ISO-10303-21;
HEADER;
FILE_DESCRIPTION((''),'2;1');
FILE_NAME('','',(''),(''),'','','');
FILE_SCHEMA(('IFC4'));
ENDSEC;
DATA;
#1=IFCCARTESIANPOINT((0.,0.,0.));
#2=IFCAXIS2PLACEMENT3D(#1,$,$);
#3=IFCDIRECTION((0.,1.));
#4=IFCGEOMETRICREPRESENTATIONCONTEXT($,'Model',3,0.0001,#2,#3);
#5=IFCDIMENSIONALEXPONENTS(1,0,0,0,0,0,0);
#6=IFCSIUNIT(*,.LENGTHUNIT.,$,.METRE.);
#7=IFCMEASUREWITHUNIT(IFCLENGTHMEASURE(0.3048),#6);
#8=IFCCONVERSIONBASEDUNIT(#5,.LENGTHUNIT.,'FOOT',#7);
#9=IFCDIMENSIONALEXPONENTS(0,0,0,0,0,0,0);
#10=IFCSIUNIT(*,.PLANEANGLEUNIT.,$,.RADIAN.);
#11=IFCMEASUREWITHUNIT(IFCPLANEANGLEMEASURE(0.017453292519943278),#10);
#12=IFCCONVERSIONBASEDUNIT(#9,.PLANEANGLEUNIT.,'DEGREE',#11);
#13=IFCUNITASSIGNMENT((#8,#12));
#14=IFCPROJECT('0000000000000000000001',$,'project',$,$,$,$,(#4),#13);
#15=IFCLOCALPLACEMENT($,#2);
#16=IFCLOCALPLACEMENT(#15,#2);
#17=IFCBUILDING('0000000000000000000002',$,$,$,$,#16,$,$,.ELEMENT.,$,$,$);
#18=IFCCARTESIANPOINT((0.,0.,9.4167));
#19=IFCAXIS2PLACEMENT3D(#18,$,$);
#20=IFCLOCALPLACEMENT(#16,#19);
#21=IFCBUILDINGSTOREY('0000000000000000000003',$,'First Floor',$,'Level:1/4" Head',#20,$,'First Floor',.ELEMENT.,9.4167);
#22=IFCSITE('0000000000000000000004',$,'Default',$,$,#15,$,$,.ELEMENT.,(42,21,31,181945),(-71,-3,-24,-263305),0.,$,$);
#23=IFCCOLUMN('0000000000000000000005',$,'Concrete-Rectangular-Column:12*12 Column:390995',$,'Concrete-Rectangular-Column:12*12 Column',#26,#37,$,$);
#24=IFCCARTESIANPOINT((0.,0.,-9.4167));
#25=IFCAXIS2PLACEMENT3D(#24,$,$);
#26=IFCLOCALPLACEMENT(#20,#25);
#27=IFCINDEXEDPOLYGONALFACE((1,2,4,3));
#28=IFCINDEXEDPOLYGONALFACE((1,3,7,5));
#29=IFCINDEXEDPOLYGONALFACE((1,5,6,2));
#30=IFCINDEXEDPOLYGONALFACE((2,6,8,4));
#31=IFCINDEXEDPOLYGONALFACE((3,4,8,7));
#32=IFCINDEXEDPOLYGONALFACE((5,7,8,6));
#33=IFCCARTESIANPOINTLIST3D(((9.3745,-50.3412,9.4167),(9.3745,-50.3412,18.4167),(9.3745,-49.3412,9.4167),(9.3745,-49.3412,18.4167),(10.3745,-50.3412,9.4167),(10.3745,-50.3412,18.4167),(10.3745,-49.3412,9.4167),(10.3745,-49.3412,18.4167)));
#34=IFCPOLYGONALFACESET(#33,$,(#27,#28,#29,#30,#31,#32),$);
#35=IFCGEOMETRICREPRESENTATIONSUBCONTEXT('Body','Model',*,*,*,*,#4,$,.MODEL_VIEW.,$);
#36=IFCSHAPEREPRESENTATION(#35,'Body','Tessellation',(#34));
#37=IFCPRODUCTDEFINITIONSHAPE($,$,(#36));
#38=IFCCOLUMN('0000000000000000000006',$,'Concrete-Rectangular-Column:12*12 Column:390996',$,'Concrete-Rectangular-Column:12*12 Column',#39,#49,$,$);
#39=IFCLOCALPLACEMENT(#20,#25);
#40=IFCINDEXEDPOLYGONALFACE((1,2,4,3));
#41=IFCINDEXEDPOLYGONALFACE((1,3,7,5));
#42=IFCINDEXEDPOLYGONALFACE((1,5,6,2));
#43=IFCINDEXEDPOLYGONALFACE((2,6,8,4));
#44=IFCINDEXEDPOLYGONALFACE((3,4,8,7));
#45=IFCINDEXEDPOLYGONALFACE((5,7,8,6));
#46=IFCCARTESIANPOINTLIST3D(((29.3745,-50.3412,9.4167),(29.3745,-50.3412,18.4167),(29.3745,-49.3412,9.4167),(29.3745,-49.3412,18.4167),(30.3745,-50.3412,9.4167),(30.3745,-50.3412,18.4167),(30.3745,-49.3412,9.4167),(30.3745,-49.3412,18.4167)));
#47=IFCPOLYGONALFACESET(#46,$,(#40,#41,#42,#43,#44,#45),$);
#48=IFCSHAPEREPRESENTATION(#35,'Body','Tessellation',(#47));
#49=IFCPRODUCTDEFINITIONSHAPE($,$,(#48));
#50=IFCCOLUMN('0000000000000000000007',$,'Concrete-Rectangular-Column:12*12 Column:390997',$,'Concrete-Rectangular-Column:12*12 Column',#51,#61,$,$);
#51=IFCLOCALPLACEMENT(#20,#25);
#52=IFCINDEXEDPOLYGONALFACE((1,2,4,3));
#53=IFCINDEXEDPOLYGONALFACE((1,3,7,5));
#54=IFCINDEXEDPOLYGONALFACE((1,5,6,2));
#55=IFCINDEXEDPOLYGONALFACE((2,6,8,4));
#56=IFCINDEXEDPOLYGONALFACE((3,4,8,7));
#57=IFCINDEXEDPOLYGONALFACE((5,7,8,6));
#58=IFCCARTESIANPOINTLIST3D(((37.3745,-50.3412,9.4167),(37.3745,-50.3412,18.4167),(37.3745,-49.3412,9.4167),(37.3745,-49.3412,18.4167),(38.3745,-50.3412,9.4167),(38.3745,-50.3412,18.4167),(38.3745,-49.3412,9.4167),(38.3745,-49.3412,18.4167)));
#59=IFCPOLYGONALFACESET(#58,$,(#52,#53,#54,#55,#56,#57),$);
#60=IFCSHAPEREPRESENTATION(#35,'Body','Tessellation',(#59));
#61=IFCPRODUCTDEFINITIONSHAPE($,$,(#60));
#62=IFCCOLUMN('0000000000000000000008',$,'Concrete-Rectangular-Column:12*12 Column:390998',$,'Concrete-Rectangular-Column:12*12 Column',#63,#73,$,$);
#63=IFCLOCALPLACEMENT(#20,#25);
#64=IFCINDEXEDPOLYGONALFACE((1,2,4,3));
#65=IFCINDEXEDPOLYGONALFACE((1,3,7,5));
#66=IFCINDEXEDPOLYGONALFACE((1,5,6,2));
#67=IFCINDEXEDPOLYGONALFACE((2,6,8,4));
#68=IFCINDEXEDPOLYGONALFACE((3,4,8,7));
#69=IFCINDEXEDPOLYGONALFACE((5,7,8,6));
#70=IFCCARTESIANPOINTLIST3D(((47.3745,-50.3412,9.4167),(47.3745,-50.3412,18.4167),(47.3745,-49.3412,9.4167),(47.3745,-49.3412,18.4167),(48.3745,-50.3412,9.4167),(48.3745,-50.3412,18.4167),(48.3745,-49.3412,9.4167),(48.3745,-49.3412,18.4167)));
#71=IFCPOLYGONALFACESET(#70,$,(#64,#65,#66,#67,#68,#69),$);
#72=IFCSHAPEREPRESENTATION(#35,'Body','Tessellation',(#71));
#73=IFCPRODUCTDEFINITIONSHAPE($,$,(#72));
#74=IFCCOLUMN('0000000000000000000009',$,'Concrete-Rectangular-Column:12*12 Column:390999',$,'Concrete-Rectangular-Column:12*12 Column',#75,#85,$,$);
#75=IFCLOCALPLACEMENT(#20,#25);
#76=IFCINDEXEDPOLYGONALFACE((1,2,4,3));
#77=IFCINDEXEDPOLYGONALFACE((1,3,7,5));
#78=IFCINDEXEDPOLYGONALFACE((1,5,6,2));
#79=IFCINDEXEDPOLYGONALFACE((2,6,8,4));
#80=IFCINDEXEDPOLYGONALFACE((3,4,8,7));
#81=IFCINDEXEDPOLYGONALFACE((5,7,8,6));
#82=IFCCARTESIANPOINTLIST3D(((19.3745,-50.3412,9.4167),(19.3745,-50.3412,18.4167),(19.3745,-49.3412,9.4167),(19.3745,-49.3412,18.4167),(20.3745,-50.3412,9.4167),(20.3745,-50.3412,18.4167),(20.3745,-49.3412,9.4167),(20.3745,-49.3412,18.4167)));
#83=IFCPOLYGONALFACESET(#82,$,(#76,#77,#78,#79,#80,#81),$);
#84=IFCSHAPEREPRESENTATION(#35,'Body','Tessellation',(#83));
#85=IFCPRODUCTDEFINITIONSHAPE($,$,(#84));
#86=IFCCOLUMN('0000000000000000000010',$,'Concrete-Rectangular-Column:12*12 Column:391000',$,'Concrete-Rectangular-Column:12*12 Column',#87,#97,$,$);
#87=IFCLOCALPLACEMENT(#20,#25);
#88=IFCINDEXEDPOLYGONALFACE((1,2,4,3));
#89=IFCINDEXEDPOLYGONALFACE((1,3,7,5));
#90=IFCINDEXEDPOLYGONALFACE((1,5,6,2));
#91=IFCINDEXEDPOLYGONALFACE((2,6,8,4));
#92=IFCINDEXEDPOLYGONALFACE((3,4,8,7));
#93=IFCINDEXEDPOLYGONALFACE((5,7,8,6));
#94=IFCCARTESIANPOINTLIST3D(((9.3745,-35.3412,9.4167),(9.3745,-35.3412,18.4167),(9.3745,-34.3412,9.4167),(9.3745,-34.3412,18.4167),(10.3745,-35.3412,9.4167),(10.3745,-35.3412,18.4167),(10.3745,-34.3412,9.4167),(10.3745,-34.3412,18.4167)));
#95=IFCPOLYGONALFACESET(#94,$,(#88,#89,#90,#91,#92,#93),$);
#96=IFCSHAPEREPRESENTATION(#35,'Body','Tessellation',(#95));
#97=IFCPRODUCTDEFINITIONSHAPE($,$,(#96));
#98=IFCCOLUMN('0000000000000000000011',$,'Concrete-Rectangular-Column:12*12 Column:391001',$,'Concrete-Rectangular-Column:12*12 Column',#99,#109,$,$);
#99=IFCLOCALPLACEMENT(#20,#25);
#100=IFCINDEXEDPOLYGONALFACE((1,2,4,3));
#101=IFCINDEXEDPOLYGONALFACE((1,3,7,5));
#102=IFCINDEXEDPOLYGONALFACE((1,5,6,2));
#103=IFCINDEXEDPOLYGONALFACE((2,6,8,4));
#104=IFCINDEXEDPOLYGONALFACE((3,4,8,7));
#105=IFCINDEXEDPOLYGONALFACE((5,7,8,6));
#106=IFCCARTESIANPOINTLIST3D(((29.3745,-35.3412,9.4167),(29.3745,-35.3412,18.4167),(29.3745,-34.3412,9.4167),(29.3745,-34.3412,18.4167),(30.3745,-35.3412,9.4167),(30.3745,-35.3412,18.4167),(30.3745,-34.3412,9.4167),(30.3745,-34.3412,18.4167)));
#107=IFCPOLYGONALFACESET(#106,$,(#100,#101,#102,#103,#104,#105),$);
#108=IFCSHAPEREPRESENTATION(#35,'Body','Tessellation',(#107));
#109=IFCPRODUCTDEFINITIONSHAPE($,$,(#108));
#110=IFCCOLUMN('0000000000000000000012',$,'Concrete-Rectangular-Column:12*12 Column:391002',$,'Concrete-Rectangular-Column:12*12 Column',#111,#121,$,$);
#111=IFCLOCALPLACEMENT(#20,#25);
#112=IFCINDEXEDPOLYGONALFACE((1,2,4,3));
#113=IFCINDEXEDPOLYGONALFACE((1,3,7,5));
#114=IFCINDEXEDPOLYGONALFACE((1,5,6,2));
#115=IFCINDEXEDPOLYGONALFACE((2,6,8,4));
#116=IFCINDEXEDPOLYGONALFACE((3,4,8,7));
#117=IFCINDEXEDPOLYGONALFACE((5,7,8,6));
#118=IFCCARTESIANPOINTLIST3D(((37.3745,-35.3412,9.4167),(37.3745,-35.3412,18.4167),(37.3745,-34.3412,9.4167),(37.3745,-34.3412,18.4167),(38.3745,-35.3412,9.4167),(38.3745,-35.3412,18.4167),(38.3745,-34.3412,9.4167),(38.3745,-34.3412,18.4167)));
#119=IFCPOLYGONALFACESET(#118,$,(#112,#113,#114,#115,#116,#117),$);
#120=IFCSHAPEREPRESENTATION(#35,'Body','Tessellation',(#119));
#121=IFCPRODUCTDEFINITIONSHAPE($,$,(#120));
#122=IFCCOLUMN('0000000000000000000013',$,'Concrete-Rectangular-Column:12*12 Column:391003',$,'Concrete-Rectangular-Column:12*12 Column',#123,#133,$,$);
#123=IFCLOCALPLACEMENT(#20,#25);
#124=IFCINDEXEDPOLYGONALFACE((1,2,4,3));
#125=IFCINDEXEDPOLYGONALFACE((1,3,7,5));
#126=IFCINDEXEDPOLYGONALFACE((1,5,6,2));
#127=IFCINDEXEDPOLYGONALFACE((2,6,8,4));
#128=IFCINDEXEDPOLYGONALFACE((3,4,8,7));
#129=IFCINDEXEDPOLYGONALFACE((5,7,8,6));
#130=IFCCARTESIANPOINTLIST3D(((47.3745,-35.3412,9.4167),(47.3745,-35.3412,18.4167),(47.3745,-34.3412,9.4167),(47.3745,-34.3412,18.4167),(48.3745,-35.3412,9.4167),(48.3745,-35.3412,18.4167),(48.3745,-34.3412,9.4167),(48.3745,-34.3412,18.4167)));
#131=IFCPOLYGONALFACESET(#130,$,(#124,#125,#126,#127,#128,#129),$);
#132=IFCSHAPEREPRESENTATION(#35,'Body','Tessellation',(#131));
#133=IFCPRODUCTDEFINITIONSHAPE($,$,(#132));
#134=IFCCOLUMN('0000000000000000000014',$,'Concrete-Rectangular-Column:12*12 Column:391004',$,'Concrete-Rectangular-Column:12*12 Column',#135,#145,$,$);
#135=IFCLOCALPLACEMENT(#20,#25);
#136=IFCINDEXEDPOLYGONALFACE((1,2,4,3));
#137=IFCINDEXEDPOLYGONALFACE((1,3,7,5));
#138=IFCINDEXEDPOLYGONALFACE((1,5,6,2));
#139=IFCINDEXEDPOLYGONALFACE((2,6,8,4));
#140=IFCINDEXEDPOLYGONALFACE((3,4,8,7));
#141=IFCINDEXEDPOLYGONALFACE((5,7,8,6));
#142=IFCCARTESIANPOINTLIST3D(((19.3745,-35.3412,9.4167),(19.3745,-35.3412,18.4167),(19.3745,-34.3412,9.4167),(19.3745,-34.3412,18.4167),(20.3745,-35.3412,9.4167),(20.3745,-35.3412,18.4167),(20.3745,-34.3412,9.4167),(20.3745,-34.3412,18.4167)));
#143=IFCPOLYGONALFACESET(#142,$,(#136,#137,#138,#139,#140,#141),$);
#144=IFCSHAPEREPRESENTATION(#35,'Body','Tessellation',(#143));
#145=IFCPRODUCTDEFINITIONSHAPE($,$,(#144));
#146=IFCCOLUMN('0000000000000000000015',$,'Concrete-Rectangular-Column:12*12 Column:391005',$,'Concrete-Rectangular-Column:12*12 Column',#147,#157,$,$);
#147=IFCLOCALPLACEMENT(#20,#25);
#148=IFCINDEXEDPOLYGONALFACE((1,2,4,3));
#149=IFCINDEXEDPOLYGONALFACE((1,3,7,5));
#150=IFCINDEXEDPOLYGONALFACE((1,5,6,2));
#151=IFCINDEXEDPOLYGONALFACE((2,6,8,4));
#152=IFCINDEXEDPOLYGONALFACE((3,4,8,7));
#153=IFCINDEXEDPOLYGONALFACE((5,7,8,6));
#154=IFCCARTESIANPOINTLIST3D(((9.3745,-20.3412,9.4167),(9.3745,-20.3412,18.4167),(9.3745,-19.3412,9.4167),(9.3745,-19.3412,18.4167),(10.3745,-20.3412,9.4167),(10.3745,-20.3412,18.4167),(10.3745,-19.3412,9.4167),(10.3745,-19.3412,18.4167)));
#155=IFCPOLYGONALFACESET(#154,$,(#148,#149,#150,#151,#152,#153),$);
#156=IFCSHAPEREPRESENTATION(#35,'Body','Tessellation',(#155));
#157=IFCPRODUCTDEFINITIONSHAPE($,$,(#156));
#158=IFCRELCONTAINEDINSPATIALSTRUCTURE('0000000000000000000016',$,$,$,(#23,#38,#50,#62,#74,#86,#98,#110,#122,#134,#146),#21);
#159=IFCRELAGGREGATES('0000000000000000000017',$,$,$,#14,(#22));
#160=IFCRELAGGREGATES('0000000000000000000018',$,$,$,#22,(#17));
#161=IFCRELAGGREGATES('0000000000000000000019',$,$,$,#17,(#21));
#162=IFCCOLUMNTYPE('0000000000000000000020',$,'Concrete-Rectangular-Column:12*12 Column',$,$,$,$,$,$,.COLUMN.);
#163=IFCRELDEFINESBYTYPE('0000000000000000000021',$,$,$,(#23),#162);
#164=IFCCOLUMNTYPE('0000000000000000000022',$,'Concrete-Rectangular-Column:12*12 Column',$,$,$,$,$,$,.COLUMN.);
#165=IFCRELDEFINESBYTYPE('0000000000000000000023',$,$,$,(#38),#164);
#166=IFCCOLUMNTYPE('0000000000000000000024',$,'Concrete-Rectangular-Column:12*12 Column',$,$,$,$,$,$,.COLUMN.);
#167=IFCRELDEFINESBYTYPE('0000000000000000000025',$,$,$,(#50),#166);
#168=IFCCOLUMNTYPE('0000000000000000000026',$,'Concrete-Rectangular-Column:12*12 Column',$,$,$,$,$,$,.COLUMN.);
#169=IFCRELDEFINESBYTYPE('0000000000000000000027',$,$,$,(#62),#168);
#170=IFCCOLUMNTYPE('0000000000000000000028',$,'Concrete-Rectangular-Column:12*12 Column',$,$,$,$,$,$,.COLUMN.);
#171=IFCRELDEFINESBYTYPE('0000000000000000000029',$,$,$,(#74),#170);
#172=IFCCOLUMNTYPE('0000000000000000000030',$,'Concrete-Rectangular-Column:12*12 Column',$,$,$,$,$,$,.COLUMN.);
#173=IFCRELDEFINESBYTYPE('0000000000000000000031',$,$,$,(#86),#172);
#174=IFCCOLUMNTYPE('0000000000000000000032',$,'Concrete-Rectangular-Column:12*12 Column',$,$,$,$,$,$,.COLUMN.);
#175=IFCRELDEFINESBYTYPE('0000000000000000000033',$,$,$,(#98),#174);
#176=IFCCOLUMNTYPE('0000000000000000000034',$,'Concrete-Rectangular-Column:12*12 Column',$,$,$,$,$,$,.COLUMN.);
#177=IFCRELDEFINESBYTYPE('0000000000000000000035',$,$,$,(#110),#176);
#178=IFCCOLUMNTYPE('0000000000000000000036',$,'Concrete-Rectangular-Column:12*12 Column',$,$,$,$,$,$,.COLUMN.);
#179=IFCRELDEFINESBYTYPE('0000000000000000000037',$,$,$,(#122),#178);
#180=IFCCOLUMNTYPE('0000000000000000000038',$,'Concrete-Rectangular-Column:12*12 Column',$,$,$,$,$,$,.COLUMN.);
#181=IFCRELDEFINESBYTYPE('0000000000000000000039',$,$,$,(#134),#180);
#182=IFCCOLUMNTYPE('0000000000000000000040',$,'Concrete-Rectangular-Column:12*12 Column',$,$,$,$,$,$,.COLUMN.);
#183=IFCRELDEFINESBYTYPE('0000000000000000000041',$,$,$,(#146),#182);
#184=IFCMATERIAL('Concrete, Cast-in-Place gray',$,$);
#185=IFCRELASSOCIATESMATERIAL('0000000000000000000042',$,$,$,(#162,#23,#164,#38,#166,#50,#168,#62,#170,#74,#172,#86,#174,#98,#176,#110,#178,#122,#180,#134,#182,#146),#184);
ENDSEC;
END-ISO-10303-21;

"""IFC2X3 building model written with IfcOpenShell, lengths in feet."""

from ifc_helpers import new_model, entity, si_unit, converted_unit, direction, frame, frame_2d, origin, origin_2d_with_axis, place, context, subcontext, project, spatial, rectangle, extrude, source, transform, mapped, material, type_object, type_shapes, element, save


model = new_model("IFC2X3")

# Units and contexts
model_context = context("Model", 3, precision=0.0001, world=origin(), true_north=direction((0.0, 1.0)))
body_context = subcontext(model_context, "Body", "Model", "MODEL_VIEW")
ifc_project = project(units=[converted_unit("LENGTHUNIT", "FOOT", entity("IfcLengthMeasure", 0.3048), si_unit("LENGTHUNIT", "METRE"), dimensions=[1, 0, 0, 0, 0, 0, 0]), converted_unit("PLANEANGLEUNIT", "DEGREE", entity("IfcPlaneAngleMeasure", 0.017453292519943278), si_unit("PLANEANGLEUNIT", "RADIAN"), dimensions=[0, 0, 0, 0, 0, 0, 0])], contexts=[model_context])

# Site, building, storey
site_placement = place(None, origin())
site = spatial("IfcSite", under=ifc_project, at=site_placement, Name="Default", CompositionType="ELEMENT", RefLatitude=(42, 21, 31, 181945), RefLongitude=(-71, -3, -24, -263305), RefElevation=0.0)
building_placement = place(site_placement, origin())
building = spatial("IfcBuilding", under=site, at=building_placement, CompositionType="ELEMENT")
storey_placement = place(building_placement, frame((0.0, 0.0, 9.4167)))
storey = spatial("IfcBuildingStorey", under=building, at=storey_placement, Name="First Floor", ObjectType="Level:1/4\" Head", LongName="First Floor", CompositionType="ELEMENT", Elevation=9.4167)

# Columns
ifc_material_1 = material(Name="Concrete, Cast-in-Place gray")
column_type_1 = type_object("IfcColumnType", Name="Concrete-Rectangular-Column:12*12 Column", PredefinedType="COLUMN", material=ifc_material_1)
shared_shape_1 = source(origin(), body_context, "Body", "SweptSolid", [
    extrude(rectangle(XDim=1.0, YDim=1.0, at=origin_2d_with_axis()), frame((9.8745, -49.8412, 9.4167), z_axis=(0.0, 0.0, 1.0), x_axis=(-1.0, 0.0, 0.0)), (0.0, 0.0, 1.0), 9.0),
])
type_shapes(column_type_1, [shared_shape_1])
column_1_placement = place(storey_placement, frame((0.0, 0.0, -9.4167)))
element("IfcColumn", 1, at=column_1_placement, inside=storey, type_object=column_type_1, material=ifc_material_1, Name="Concrete-Rectangular-Column:12*12 Column:390995", ObjectType="Concrete-Rectangular-Column:12*12 Column", context=body_context, shape_type="MappedRepresentation", body=[
    mapped(shared_shape_1, transform((0.0, 0.0, 0.0), scale=1.0)),
])
column_type_2 = type_object("IfcColumnType", Name="Concrete-Rectangular-Column:12*12 Column", PredefinedType="COLUMN", material=ifc_material_1)
shared_shape_2 = source(origin(), body_context, "Body", "SweptSolid", [
    extrude(rectangle(XDim=1.0, YDim=1.0, at=frame_2d((0.0, 0.0), x_axis=(1.0, 0.0))), frame((29.8745, -49.8412, 9.4167), z_axis=(0.0, 0.0, 1.0), x_axis=(-1.0, 0.0, 0.0)), (0.0, 0.0, 1.0), 9.0),
])
type_shapes(column_type_2, [shared_shape_2])
column_2_placement = place(storey_placement, frame((0.0, 0.0, -9.4167)))
element("IfcColumn", 2, at=column_2_placement, inside=storey, type_object=column_type_2, material=ifc_material_1, Name="Concrete-Rectangular-Column:12*12 Column:390996", ObjectType="Concrete-Rectangular-Column:12*12 Column", context=body_context, shape_type="MappedRepresentation", body=[
    mapped(shared_shape_2, transform((0.0, 0.0, 0.0), scale=1.0)),
])
column_type_3 = type_object("IfcColumnType", Name="Concrete-Rectangular-Column:12*12 Column", PredefinedType="COLUMN", material=ifc_material_1)
shared_shape_3 = source(origin(), body_context, "Body", "SweptSolid", [
    extrude(rectangle(XDim=1.0, YDim=1.0, at=origin_2d_with_axis()), frame((37.8745, -49.8412, 9.4167), z_axis=(0.0, 0.0, 1.0), x_axis=(-1.0, 0.0, 0.0)), (0.0, 0.0, 1.0), 9.0),
])
type_shapes(column_type_3, [shared_shape_3])
column_3_placement = place(storey_placement, frame((0.0, 0.0, -9.4167)))
element("IfcColumn", 3, at=column_3_placement, inside=storey, type_object=column_type_3, material=ifc_material_1, Name="Concrete-Rectangular-Column:12*12 Column:390997", ObjectType="Concrete-Rectangular-Column:12*12 Column", context=body_context, shape_type="MappedRepresentation", body=[
    mapped(shared_shape_3, transform((0.0, 0.0, 0.0), scale=1.0)),
])
column_type_4 = type_object("IfcColumnType", Name="Concrete-Rectangular-Column:12*12 Column", PredefinedType="COLUMN", material=ifc_material_1)
shared_shape_4 = source(origin(), body_context, "Body", "SweptSolid", [
    extrude(rectangle(XDim=1.0, YDim=1.0, at=origin_2d_with_axis()), frame((47.8745, -49.8412, 9.4167), z_axis=(0.0, 0.0, 1.0), x_axis=(-1.0, 0.0, 0.0)), (0.0, 0.0, 1.0), 9.0),
])
type_shapes(column_type_4, [shared_shape_4])
column_4_placement = place(storey_placement, frame((0.0, 0.0, -9.4167)))
element("IfcColumn", 4, at=column_4_placement, inside=storey, type_object=column_type_4, material=ifc_material_1, Name="Concrete-Rectangular-Column:12*12 Column:390998", ObjectType="Concrete-Rectangular-Column:12*12 Column", context=body_context, shape_type="MappedRepresentation", body=[
    mapped(shared_shape_4, transform((0.0, 0.0, 0.0), scale=1.0)),
])
column_type_5 = type_object("IfcColumnType", Name="Concrete-Rectangular-Column:12*12 Column", PredefinedType="COLUMN", material=ifc_material_1)
shared_shape_5 = source(origin(), body_context, "Body", "SweptSolid", [
    extrude(rectangle(XDim=1.0, YDim=1.0, at=frame_2d((0.0, 0.0), x_axis=(1.0, 0.0))), frame((19.8745, -49.8412, 9.4167), z_axis=(0.0, 0.0, 1.0), x_axis=(-1.0, 0.0, 0.0)), (0.0, 0.0, 1.0), 9.0),
])
type_shapes(column_type_5, [shared_shape_5])
column_5_placement = place(storey_placement, frame((0.0, 0.0, -9.4167)))
element("IfcColumn", 5, at=column_5_placement, inside=storey, type_object=column_type_5, material=ifc_material_1, Name="Concrete-Rectangular-Column:12*12 Column:390999", ObjectType="Concrete-Rectangular-Column:12*12 Column", context=body_context, shape_type="MappedRepresentation", body=[
    mapped(shared_shape_5, transform((0.0, 0.0, 0.0), scale=1.0)),
])
column_type_6 = type_object("IfcColumnType", Name="Concrete-Rectangular-Column:12*12 Column", PredefinedType="COLUMN", material=ifc_material_1)
shared_shape_6 = source(origin(), body_context, "Body", "SweptSolid", [
    extrude(rectangle(XDim=1.0, YDim=1.0, at=origin_2d_with_axis()), frame((9.8745, -34.8412, 9.4167), z_axis=(0.0, 0.0, 1.0), x_axis=(-1.0, 0.0, 0.0)), (0.0, 0.0, 1.0), 9.0),
])
type_shapes(column_type_6, [shared_shape_6])
column_6_placement = place(storey_placement, frame((0.0, 0.0, -9.4167)))
element("IfcColumn", 6, at=column_6_placement, inside=storey, type_object=column_type_6, material=ifc_material_1, Name="Concrete-Rectangular-Column:12*12 Column:391000", ObjectType="Concrete-Rectangular-Column:12*12 Column", context=body_context, shape_type="MappedRepresentation", body=[
    mapped(shared_shape_6, transform((0.0, 0.0, 0.0), scale=1.0)),
])
column_type_7 = type_object("IfcColumnType", Name="Concrete-Rectangular-Column:12*12 Column", PredefinedType="COLUMN", material=ifc_material_1)
shared_shape_7 = source(origin(), body_context, "Body", "SweptSolid", [
    extrude(rectangle(XDim=1.0, YDim=1.0, at=frame_2d((0.0, 0.0), x_axis=(1.0, 0.0))), frame((29.8745, -34.8412, 9.4167), z_axis=(0.0, 0.0, 1.0), x_axis=(-1.0, 0.0, 0.0)), (0.0, 0.0, 1.0), 9.0),
])
type_shapes(column_type_7, [shared_shape_7])
column_7_placement = place(storey_placement, frame((0.0, 0.0, -9.4167)))
element("IfcColumn", 7, at=column_7_placement, inside=storey, type_object=column_type_7, material=ifc_material_1, Name="Concrete-Rectangular-Column:12*12 Column:391001", ObjectType="Concrete-Rectangular-Column:12*12 Column", context=body_context, shape_type="MappedRepresentation", body=[
    mapped(shared_shape_7, transform((0.0, 0.0, 0.0), scale=1.0)),
])
column_type_8 = type_object("IfcColumnType", Name="Concrete-Rectangular-Column:12*12 Column", PredefinedType="COLUMN", material=ifc_material_1)
shared_shape_8 = source(origin(), body_context, "Body", "SweptSolid", [
    extrude(rectangle(XDim=1.0, YDim=1.0, at=origin_2d_with_axis()), frame((37.8745, -34.8412, 9.4167), z_axis=(0.0, 0.0, 1.0), x_axis=(-1.0, 0.0, 0.0)), (0.0, 0.0, 1.0), 9.0),
])
type_shapes(column_type_8, [shared_shape_8])
column_8_placement = place(storey_placement, frame((0.0, 0.0, -9.4167)))
element("IfcColumn", 8, at=column_8_placement, inside=storey, type_object=column_type_8, material=ifc_material_1, Name="Concrete-Rectangular-Column:12*12 Column:391002", ObjectType="Concrete-Rectangular-Column:12*12 Column", context=body_context, shape_type="MappedRepresentation", body=[
    mapped(shared_shape_8, transform((0.0, 0.0, 0.0), scale=1.0)),
])
column_type_9 = type_object("IfcColumnType", Name="Concrete-Rectangular-Column:12*12 Column", PredefinedType="COLUMN", material=ifc_material_1)
shared_shape_9 = source(origin(), body_context, "Body", "SweptSolid", [
    extrude(rectangle(XDim=1.0, YDim=1.0, at=origin_2d_with_axis()), frame((47.8745, -34.8412, 9.4167), z_axis=(0.0, 0.0, 1.0), x_axis=(-1.0, 0.0, 0.0)), (0.0, 0.0, 1.0), 9.0),
])
type_shapes(column_type_9, [shared_shape_9])
column_9_placement = place(storey_placement, frame((0.0, 0.0, -9.4167)))
element("IfcColumn", 9, at=column_9_placement, inside=storey, type_object=column_type_9, material=ifc_material_1, Name="Concrete-Rectangular-Column:12*12 Column:391003", ObjectType="Concrete-Rectangular-Column:12*12 Column", context=body_context, shape_type="MappedRepresentation", body=[
    mapped(shared_shape_9, transform((0.0, 0.0, 0.0), scale=1.0)),
])
column_type_10 = type_object("IfcColumnType", Name="Concrete-Rectangular-Column:12*12 Column", PredefinedType="COLUMN", material=ifc_material_1)
shared_shape_10 = source(origin(), body_context, "Body", "SweptSolid", [
    extrude(rectangle(XDim=1.0, YDim=1.0, at=frame_2d((0.0, 0.0), x_axis=(1.0, 0.0))), frame((19.8745, -34.8412, 9.4167), z_axis=(0.0, 0.0, 1.0), x_axis=(-1.0, 0.0, 0.0)), (0.0, 0.0, 1.0), 9.0),
])
type_shapes(column_type_10, [shared_shape_10])
column_10_placement = place(storey_placement, frame((0.0, 0.0, -9.4167)))
element("IfcColumn", 10, at=column_10_placement, inside=storey, type_object=column_type_10, material=ifc_material_1, Name="Concrete-Rectangular-Column:12*12 Column:391004", ObjectType="Concrete-Rectangular-Column:12*12 Column", context=body_context, shape_type="MappedRepresentation", body=[
    mapped(shared_shape_10, transform((0.0, 0.0, 0.0), scale=1.0)),
])
column_type_11 = type_object("IfcColumnType", Name="Concrete-Rectangular-Column:12*12 Column", PredefinedType="COLUMN", material=ifc_material_1)
shared_shape_11 = source(origin(), body_context, "Body", "SweptSolid", [
    extrude(rectangle(XDim=1.0, YDim=1.0, at=frame_2d((0.0, 0.0), x_axis=(1.0, 0.0))), frame((9.8745, -19.8412, 9.4167), z_axis=(0.0, 0.0, 1.0), x_axis=(-1.0, 0.0, 0.0)), (0.0, 0.0, 1.0), 9.0),
])
type_shapes(column_type_11, [shared_shape_11])
column_11_placement = place(storey_placement, frame((0.0, 0.0, -9.4167)))
element("IfcColumn", 11, at=column_11_placement, inside=storey, type_object=column_type_11, material=ifc_material_1, Name="Concrete-Rectangular-Column:12*12 Column:391005", ObjectType="Concrete-Rectangular-Column:12*12 Column", context=body_context, shape_type="MappedRepresentation", body=[
    mapped(shared_shape_11, transform((0.0, 0.0, 0.0), scale=1.0)),
])

save(model, "model.ifc")
